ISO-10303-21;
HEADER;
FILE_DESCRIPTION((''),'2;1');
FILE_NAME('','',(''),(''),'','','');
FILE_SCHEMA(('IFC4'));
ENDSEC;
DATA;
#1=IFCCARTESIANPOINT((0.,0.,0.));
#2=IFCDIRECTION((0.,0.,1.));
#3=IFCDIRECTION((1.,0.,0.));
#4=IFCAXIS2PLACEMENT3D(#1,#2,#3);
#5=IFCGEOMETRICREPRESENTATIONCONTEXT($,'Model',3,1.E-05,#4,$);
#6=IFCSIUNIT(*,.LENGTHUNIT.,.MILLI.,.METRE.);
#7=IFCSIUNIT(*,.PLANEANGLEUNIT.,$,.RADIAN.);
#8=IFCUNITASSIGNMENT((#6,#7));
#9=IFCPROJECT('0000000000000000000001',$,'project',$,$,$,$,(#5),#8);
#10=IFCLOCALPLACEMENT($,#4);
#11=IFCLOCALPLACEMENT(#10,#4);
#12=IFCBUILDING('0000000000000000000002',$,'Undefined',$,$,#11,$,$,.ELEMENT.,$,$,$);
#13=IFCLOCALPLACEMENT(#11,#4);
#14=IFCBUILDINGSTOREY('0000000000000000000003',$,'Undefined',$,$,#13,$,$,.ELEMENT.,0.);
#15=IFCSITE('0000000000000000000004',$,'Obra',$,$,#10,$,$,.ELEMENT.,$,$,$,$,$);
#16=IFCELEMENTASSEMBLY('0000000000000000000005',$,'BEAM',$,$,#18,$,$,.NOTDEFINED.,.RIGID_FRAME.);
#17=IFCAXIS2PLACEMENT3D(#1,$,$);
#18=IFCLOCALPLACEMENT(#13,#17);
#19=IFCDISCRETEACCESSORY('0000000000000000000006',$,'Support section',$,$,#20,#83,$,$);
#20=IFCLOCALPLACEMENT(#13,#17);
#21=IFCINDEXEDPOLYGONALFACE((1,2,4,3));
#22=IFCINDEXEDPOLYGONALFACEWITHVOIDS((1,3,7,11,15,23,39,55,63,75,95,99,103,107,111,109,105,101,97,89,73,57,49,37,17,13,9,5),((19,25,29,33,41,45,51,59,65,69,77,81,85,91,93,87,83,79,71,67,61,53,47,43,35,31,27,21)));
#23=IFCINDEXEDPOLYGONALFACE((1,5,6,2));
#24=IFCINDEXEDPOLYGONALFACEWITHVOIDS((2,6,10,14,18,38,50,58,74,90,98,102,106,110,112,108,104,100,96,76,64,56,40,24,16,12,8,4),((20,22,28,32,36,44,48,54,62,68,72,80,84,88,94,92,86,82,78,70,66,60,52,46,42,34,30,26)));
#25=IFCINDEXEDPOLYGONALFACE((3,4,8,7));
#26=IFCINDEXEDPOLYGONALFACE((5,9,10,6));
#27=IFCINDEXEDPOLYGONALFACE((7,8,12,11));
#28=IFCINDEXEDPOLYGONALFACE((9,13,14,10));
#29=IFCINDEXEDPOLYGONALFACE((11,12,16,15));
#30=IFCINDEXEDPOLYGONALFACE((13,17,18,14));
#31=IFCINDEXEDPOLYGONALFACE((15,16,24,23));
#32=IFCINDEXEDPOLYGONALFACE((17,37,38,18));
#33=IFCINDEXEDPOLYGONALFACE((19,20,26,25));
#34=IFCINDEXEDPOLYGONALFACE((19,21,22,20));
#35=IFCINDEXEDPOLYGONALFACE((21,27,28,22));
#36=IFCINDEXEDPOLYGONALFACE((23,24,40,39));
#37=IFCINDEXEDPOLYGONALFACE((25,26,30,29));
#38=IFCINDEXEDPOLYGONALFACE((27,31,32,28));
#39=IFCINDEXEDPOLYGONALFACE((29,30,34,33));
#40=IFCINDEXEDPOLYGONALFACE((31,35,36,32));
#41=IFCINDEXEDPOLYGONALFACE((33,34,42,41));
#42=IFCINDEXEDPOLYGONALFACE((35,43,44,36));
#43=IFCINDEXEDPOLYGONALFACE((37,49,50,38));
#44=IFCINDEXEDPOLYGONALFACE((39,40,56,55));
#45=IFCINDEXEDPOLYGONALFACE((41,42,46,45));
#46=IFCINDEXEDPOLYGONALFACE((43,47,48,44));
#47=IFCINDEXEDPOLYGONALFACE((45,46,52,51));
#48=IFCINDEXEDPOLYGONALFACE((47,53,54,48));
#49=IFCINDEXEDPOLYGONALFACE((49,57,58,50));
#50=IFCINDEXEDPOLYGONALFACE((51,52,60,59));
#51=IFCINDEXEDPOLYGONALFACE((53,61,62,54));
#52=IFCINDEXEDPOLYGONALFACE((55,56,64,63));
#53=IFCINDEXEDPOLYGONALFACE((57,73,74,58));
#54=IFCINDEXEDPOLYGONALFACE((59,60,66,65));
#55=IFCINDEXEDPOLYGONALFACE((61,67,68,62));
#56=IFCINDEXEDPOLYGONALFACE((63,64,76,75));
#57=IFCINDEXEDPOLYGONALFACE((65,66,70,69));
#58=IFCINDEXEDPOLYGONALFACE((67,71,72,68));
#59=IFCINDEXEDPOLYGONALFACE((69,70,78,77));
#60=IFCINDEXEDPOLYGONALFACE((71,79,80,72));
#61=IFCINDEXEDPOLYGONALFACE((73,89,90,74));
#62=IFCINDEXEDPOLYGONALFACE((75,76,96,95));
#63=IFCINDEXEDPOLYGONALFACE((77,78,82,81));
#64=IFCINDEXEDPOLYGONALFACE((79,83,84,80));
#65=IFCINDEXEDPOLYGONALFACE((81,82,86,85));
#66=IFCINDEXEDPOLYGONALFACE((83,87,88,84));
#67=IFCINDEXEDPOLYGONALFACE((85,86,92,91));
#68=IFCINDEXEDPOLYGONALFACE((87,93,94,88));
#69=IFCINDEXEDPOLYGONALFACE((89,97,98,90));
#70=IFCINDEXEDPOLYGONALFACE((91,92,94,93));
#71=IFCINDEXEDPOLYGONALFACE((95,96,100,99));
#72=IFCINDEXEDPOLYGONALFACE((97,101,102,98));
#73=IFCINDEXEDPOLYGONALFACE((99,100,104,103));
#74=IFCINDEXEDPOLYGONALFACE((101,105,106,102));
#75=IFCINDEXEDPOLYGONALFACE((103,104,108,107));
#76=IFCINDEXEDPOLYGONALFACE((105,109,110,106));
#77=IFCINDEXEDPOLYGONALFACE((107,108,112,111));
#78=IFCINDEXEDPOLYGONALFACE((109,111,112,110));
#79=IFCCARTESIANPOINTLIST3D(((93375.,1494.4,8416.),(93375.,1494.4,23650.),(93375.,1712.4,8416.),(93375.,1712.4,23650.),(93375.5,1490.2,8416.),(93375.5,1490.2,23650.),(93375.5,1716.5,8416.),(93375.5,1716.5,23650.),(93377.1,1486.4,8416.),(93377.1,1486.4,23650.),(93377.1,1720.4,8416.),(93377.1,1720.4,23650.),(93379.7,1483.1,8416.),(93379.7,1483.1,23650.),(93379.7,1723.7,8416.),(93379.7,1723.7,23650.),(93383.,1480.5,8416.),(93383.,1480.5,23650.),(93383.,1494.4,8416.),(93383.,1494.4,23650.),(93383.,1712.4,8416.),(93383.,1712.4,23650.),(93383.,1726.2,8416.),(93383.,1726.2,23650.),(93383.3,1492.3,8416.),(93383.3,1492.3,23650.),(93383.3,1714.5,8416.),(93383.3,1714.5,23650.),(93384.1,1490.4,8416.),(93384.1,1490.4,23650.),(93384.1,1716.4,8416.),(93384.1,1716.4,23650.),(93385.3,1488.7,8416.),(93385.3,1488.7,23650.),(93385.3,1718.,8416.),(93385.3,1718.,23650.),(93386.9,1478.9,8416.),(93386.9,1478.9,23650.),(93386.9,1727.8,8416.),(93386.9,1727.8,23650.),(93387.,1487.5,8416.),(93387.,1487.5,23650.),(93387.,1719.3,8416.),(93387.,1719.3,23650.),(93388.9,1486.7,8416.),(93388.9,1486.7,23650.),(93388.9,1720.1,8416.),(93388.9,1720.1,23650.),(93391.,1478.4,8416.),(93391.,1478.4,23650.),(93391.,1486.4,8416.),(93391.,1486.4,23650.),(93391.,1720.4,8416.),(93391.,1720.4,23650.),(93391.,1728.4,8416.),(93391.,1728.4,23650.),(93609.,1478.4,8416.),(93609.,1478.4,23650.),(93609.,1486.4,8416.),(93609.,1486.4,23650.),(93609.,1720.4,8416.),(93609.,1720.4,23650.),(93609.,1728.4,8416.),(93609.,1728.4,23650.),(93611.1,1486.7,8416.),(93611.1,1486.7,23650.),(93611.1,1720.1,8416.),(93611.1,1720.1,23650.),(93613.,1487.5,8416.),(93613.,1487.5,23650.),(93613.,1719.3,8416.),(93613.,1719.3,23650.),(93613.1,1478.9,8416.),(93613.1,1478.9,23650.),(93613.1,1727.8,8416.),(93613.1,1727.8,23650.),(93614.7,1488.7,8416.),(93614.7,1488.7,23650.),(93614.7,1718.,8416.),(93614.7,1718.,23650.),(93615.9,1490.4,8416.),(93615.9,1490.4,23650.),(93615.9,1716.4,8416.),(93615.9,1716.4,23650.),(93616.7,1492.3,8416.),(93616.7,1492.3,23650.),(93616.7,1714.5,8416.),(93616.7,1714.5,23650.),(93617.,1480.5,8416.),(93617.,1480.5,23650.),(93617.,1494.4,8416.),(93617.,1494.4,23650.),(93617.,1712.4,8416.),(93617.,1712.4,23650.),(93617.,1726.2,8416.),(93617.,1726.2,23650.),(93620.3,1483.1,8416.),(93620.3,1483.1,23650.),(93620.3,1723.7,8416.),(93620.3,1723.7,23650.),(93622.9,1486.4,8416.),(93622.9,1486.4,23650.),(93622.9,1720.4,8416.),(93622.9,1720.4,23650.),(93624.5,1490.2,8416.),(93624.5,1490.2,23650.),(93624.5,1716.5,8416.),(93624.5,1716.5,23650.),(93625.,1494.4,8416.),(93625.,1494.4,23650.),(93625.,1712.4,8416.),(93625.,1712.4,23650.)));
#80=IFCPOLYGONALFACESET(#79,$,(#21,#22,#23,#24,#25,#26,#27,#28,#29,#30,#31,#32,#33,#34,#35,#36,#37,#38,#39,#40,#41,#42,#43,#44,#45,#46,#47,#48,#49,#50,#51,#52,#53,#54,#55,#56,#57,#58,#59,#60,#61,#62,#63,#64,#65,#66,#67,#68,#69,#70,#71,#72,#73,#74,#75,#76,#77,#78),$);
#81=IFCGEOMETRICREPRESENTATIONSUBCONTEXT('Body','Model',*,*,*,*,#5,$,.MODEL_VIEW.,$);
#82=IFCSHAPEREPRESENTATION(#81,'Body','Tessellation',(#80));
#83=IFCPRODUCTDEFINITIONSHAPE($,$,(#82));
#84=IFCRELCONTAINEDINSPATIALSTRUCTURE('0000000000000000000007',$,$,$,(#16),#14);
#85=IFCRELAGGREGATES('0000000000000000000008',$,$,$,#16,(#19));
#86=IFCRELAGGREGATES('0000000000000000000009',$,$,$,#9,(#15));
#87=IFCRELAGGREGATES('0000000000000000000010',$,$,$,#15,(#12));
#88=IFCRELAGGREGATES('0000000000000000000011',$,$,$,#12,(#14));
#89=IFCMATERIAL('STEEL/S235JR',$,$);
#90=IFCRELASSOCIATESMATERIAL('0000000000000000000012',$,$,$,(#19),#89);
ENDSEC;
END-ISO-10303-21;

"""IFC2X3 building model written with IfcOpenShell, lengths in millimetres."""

from ifc_helpers import new_model, si_unit, frame, origin_with_axes, origin_2d_with_axis, place, context, subcontext, project, spatial, hollow_rectangle, extrude, clip, halfspace, material, element, aggregate, save


model = new_model("IFC2X3")

# Units and contexts
model_context = context("Model", 3, precision=1e-05, world=origin_with_axes())
body_context = subcontext(model_context, "Body", "Model", "MODEL_VIEW")
ifc_project = project(units=[si_unit("LENGTHUNIT", "METRE", prefix="MILLI"), si_unit("PLANEANGLEUNIT", "RADIAN")], contexts=[model_context])

# Site, building, storey
site_placement = place(None, origin_with_axes())
site = spatial("IfcSite", under=ifc_project, at=site_placement, Name="Obra", CompositionType="ELEMENT")
building_placement = place(site_placement, origin_with_axes())
building = spatial("IfcBuilding", under=site, at=building_placement, Name="Undefined", CompositionType="ELEMENT")
storey_placement = place(building_placement, origin_with_axes())
storey = spatial("IfcBuildingStorey", under=building, at=storey_placement, Name="Undefined", CompositionType="ELEMENT", Elevation=0.0)

# Shared definitions
ifc_material_1 = material(Name="STEEL/S235JR")

# Element assembly
assembly_1_placement = place(storey_placement, origin_with_axes())
assembly_1 = element("IfcElementAssembly", 1, at=assembly_1_placement, inside=storey, Name="BEAM", AssemblyPlace="NOTDEFINED", PredefinedType="RIGID_FRAME")

# Discrete accessory
discrete_accessory_1_placement = place(assembly_1_placement, frame((93500.0, 1603.4, 8400.0), z_axis=(0.0, 0.0, 1.0), x_axis=(0.0, 1.0, 0.0)))
discrete_accessory_1 = element("IfcDiscreteAccessory", 2, at=discrete_accessory_1_placement, material=ifc_material_1, Name="Support section", context=body_context, shape_type="Clipping", body=[
    clip(extrude(hollow_rectangle(XDim=250.0, YDim=250.0, WallThickness=8.0, InnerFilletRadius=8.0, OuterFilletRadius=16.0, at=origin_2d_with_axis()), frame((0.0, 0.0, 15250.0), z_axis=(0.0, 0.0, -1.0), x_axis=(0.0, 1.0, 0.0)), (0.0, 0.0, 1.0), 15234.0), halfspace(frame((-125.0, 0.0, 16.0), z_axis=(0.0, 0.0, 1.0), x_axis=(0.0, 1.0, 0.0)), True)),
])
aggregate(assembly_1, [discrete_accessory_1])

save(model, "model.ifc")
